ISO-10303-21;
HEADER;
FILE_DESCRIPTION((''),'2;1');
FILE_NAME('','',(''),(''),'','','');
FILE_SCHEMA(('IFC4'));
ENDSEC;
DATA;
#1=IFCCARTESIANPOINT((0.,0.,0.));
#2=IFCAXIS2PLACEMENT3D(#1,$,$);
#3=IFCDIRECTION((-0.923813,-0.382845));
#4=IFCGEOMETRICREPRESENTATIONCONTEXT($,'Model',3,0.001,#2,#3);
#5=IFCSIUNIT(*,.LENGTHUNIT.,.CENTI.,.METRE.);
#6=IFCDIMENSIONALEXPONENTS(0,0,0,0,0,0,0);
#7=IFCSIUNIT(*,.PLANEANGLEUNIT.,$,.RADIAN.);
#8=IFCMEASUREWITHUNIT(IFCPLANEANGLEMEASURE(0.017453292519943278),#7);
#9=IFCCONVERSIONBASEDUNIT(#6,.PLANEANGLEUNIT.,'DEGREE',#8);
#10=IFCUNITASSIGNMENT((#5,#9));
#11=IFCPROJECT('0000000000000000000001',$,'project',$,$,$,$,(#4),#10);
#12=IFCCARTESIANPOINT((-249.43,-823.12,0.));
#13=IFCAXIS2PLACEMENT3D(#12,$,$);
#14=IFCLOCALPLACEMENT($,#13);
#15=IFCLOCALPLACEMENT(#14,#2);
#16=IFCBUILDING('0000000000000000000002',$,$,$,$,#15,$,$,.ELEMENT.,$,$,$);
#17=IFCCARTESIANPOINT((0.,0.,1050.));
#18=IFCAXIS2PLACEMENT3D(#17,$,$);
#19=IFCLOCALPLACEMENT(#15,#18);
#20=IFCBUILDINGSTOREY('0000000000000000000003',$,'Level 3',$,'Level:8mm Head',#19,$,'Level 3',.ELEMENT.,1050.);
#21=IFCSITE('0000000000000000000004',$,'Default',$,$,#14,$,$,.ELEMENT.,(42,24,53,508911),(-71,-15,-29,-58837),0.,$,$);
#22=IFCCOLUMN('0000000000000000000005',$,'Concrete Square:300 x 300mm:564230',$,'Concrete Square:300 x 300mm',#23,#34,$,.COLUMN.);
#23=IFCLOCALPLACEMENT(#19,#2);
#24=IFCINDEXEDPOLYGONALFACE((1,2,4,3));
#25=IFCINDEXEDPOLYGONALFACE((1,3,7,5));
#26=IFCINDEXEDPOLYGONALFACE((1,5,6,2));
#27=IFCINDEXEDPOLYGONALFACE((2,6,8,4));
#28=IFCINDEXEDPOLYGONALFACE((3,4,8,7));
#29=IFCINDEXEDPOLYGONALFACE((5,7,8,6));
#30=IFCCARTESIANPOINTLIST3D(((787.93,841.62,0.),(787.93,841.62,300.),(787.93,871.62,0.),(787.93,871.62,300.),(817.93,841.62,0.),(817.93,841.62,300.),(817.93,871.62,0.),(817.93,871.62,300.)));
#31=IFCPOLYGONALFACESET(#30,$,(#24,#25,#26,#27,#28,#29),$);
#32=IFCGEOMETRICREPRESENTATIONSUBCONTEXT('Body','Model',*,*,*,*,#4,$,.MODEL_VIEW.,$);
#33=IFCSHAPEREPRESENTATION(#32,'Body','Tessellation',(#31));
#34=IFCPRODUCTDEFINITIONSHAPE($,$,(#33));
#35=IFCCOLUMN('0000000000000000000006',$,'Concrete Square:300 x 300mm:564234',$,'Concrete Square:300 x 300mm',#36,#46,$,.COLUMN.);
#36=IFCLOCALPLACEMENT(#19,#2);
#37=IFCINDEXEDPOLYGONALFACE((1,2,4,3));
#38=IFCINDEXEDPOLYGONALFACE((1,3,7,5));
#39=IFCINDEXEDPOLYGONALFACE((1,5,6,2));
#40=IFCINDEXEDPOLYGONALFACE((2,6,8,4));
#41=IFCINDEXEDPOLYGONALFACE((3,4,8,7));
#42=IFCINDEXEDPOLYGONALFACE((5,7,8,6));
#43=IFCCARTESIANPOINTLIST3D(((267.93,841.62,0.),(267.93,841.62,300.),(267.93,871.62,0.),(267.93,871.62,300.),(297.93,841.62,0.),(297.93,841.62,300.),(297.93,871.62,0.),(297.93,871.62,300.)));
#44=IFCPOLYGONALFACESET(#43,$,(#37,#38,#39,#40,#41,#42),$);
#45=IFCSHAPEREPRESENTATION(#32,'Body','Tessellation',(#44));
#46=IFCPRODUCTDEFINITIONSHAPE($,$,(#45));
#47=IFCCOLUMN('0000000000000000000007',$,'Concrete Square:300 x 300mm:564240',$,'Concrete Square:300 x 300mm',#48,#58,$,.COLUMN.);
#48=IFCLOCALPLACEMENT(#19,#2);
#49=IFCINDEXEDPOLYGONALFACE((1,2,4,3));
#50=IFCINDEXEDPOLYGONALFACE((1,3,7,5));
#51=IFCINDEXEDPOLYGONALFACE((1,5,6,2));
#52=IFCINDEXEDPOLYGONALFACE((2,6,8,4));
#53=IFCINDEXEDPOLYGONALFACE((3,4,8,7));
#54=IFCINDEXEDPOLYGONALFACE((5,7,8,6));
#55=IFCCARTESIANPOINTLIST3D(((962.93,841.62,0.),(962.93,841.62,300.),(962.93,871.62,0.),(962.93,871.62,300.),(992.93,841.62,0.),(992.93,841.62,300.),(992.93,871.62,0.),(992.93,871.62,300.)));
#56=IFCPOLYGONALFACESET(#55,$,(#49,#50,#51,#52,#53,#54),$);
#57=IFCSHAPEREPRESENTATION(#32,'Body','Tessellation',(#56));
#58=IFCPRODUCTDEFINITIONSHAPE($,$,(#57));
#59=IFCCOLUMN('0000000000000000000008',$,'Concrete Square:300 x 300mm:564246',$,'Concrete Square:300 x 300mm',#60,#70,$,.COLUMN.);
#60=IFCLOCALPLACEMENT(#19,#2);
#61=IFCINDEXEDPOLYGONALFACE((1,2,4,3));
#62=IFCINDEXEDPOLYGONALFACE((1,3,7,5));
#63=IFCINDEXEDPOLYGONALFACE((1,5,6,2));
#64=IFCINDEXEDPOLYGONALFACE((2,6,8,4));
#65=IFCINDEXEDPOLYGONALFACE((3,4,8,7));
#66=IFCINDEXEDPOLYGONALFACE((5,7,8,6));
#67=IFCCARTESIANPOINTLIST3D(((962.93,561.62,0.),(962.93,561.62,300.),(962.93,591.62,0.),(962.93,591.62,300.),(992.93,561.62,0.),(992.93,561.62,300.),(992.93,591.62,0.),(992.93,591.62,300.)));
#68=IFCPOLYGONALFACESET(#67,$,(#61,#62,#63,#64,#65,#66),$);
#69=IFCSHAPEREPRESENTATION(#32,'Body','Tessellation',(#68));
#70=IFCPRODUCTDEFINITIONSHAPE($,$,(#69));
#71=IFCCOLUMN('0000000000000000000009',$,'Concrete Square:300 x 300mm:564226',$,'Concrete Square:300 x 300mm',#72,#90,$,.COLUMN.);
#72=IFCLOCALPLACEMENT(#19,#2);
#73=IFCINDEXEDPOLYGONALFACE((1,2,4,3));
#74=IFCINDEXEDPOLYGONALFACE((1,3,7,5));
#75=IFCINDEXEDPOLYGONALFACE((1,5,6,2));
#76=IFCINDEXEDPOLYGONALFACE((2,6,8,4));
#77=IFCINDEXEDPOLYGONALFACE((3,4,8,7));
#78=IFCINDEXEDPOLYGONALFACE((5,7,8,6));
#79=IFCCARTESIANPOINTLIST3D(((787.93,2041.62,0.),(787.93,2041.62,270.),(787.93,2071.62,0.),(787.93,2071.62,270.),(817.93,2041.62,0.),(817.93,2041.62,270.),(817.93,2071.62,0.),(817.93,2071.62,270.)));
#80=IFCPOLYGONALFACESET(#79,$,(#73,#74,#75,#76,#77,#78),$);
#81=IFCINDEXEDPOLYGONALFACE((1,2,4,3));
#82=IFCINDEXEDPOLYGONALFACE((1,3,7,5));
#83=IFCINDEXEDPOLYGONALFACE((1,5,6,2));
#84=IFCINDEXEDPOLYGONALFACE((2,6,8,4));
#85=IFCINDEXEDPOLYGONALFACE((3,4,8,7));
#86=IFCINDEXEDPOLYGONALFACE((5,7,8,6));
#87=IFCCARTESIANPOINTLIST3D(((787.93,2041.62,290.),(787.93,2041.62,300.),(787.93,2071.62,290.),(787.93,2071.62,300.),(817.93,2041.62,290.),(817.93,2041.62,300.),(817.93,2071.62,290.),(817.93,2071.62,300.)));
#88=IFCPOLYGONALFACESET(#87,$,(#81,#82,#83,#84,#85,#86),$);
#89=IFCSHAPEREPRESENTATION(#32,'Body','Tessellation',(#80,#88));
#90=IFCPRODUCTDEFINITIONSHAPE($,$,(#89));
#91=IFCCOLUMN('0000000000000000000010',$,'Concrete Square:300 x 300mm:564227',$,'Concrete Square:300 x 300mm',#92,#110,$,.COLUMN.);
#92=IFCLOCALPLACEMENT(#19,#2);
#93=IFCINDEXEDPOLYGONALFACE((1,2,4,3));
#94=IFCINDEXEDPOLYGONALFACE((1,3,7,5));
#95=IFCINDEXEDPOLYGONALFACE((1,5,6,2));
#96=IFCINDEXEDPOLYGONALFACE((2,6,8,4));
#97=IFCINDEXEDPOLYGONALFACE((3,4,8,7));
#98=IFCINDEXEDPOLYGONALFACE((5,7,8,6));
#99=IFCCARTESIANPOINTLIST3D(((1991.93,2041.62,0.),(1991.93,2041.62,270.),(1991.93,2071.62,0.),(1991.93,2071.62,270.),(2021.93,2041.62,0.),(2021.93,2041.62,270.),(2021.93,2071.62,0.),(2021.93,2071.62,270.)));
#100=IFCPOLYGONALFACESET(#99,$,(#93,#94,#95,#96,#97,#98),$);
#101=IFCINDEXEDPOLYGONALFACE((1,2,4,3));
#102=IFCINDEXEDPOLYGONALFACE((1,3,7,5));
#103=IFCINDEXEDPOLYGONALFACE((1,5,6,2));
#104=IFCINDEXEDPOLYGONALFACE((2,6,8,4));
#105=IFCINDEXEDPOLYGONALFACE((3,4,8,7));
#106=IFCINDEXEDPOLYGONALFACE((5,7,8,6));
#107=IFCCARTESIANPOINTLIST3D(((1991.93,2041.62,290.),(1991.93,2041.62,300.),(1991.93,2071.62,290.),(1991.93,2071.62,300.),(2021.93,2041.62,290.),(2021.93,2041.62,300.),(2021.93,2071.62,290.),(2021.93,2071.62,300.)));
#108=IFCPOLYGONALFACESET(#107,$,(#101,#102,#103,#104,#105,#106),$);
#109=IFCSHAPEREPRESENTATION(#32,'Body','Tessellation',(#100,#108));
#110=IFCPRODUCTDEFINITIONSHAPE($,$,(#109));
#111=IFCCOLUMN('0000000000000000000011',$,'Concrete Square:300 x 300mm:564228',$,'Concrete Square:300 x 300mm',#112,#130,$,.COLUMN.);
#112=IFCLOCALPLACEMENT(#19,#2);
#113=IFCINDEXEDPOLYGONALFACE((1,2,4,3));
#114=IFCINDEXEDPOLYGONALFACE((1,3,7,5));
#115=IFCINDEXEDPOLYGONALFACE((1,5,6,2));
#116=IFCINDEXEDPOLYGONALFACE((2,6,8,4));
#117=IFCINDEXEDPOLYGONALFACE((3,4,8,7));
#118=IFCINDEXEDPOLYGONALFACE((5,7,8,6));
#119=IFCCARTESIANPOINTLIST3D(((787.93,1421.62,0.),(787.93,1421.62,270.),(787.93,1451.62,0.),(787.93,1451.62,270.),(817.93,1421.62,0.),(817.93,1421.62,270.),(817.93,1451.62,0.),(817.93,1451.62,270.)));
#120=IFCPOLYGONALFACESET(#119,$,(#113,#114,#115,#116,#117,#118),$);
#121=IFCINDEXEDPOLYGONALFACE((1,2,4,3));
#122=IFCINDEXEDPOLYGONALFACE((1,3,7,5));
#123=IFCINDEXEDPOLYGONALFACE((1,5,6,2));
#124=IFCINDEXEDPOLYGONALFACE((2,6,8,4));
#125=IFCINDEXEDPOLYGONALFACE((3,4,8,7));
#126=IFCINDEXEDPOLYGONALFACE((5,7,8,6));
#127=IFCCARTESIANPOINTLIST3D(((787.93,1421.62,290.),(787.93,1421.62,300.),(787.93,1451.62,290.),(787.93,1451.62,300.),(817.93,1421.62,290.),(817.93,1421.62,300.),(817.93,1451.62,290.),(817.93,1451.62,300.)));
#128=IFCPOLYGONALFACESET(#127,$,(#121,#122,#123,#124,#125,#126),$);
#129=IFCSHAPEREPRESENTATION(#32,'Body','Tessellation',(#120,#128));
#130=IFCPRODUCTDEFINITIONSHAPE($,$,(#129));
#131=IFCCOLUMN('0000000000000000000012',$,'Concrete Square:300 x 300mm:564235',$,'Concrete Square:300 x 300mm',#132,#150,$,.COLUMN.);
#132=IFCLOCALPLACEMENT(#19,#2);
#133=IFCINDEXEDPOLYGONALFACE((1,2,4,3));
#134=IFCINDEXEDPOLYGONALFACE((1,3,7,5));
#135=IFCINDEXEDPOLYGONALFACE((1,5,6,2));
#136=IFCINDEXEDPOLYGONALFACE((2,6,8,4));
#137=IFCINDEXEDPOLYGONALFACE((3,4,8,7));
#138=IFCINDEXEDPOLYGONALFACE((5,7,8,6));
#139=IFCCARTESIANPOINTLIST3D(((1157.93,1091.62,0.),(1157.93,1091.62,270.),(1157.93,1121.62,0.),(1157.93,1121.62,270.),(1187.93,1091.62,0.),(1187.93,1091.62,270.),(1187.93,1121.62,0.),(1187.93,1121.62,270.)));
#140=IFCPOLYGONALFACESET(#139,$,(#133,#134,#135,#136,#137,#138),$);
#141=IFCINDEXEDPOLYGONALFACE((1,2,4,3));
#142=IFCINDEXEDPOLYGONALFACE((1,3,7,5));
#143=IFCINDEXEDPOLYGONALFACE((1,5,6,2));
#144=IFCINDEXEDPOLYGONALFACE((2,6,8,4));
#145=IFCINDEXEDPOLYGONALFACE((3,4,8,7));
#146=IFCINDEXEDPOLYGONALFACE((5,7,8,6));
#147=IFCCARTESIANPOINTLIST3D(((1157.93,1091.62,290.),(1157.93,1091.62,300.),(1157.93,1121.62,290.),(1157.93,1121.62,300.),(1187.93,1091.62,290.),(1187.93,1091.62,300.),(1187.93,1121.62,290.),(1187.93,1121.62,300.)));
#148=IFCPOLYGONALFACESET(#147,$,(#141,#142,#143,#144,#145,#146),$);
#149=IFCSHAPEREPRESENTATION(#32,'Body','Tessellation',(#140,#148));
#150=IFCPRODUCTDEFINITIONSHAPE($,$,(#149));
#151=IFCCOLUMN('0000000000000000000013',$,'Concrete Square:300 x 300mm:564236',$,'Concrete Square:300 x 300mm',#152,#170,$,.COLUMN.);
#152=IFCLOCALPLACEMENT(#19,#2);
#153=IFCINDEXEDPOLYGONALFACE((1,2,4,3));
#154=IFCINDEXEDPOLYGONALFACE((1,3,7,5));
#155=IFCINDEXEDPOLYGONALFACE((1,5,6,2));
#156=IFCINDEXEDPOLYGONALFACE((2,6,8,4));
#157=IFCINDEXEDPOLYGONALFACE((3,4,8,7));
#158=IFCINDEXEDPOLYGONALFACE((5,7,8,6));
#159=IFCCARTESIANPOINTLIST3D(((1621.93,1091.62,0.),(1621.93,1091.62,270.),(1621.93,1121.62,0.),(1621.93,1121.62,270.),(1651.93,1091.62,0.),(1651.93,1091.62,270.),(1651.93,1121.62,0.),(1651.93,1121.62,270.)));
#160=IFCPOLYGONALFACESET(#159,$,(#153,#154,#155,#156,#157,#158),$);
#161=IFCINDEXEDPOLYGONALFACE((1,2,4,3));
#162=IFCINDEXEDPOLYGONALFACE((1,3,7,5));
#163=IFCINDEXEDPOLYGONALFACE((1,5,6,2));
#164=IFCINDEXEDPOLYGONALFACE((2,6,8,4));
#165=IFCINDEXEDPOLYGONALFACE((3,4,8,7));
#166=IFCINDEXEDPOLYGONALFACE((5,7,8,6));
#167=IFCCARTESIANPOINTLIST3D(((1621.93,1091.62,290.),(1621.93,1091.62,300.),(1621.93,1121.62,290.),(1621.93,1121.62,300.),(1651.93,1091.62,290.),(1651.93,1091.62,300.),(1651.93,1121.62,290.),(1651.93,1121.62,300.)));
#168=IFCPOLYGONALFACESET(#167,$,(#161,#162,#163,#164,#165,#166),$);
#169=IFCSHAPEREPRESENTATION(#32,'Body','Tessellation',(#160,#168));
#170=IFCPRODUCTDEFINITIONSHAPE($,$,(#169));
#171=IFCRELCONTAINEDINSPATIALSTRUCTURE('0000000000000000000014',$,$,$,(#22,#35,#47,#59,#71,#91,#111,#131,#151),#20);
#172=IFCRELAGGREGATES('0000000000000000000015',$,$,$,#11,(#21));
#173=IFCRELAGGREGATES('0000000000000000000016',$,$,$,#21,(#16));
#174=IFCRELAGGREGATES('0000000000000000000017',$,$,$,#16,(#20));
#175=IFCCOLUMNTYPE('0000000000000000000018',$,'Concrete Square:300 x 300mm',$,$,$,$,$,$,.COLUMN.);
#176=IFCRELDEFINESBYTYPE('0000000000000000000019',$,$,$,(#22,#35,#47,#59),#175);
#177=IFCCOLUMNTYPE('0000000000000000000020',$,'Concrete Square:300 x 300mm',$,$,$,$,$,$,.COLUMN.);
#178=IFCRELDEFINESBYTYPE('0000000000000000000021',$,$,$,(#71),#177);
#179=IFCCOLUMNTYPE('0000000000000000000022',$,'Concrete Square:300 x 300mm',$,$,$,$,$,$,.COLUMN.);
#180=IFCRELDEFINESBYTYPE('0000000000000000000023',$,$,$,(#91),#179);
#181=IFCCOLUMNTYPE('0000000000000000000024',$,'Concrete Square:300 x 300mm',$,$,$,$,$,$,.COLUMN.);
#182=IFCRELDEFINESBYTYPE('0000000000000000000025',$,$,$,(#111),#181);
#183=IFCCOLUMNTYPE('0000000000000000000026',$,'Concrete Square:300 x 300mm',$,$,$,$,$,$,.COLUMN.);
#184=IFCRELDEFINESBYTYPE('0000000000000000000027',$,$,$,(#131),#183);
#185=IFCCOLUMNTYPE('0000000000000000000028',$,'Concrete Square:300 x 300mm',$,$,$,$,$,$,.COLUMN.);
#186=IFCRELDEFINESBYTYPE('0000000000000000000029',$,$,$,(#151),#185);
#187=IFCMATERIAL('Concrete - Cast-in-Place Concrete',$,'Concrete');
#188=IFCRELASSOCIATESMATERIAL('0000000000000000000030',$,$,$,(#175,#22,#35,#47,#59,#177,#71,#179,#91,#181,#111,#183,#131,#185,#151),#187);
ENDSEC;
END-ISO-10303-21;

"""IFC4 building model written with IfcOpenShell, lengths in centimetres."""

from ifc_helpers import new_model, entity, si_unit, converted_unit, direction, frame, origin, place, context, subcontext, project, spatial, indexed_curve, outline, extrude, source, transform, mapped, material, type_object, type_shapes, element, save


model = new_model("IFC4")

# Units and contexts
model_context = context("Model", 3, precision=0.001, world=origin(), true_north=direction((-0.923813, -0.382845)))
body_context = subcontext(model_context, "Body", "Model", "MODEL_VIEW")
ifc_project = project(units=[si_unit("LENGTHUNIT", "METRE", prefix="CENTI"), converted_unit("PLANEANGLEUNIT", "DEGREE", entity("IfcPlaneAngleMeasure", 0.017453292519943278), si_unit("PLANEANGLEUNIT", "RADIAN"), dimensions=[0, 0, 0, 0, 0, 0, 0])], contexts=[model_context])

# Site, building, storey
site_placement = place(None, frame((-249.43, -823.12, 0.0)))
site = spatial("IfcSite", under=ifc_project, at=site_placement, Name="Default", CompositionType="ELEMENT", RefLatitude=(42, 24, 53, 508911), RefLongitude=(-71, -15, -29, -58837), RefElevation=0.0)
building_placement = place(site_placement, origin())
building = spatial("IfcBuilding", under=site, at=building_placement, CompositionType="ELEMENT")
storey_placement = place(building_placement, frame((0.0, 0.0, 1050.0)))
storey = spatial("IfcBuildingStorey", under=building, at=storey_placement, Name="Level 3", ObjectType="Level:8mm Head", LongName="Level 3", CompositionType="ELEMENT", Elevation=1050.0)

# Columns
ifc_material_1 = material(Name="Concrete - Cast-in-Place Concrete", Category="Concrete")
column_type_1 = type_object("IfcColumnType", Name="Concrete Square:300 x 300mm", PredefinedType="COLUMN", material=ifc_material_1)
shared_shape_1 = source(origin(), body_context, "Body", "SweptSolid", [
    extrude(outline(indexed_curve([(-15.0, -15.0), (15.0, -15.0), (15.0, 15.0), (-15.0, 15.0), (-15.0, -15.0)], self_intersect=False)), frame((0.0, 0.0, 1050.0), z_axis=(0.0, 0.0, 1.0), x_axis=(-1.0, 0.0, 0.0)), (0.0, 0.0, 1.0), 300.0),
])
type_shapes(column_type_1, [shared_shape_1])
for number, where, name in (
    (1, (802.93, 856.62, -1050.0), "Concrete Square:300 x 300mm:564230"),
    (2, (282.93, 856.62, -1050.0), "Concrete Square:300 x 300mm:564234"),
    (3, (977.93, 856.62, -1050.0), "Concrete Square:300 x 300mm:564240"),
    (4, (977.93, 576.62, -1050.0), "Concrete Square:300 x 300mm:564246"),
):
    element("IfcColumn", number, at=place(storey_placement, frame(where)), inside=storey, type_object=column_type_1, material=ifc_material_1, Name=name, ObjectType="Concrete Square:300 x 300mm", PredefinedType="COLUMN", context=body_context, shape_type="MappedRepresentation", body=[
        mapped(shared_shape_1, transform((0.0, 0.0, 0.0), scale=1.0)),
    ])
column_type_2 = type_object("IfcColumnType", Name="Concrete Square:300 x 300mm", PredefinedType="COLUMN", material=ifc_material_1)
shared_shape_2 = source(origin(), body_context, "Body", "SweptSolid", [
    extrude(outline(indexed_curve([(-15.0, -15.0), (15.0, -15.0), (15.0, 15.0), (-15.0, 15.0), (-15.0, -15.0)], self_intersect=False)), frame((802.93, 2056.62, 1050.0), z_axis=(0.0, 0.0, 1.0), x_axis=(-1.0, 0.0, 0.0)), (0.0, 0.0, 1.0), 270.0),
    extrude(outline(indexed_curve([(-15.0, -15.0), (15.0, -15.0), (15.0, 15.0), (-15.0, 15.0), (-15.0, -15.0)], self_intersect=False)), frame((802.93, 2056.62, 1340.0), z_axis=(0.0, 0.0, 1.0), x_axis=(-1.0, 0.0, 0.0)), (0.0, 0.0, 1.0), 10.0),
])
type_shapes(column_type_2, [shared_shape_2])
column_1_placement = place(storey_placement, frame((0.0, 0.0, -1050.0)))
element("IfcColumn", 5, at=column_1_placement, inside=storey, type_object=column_type_2, material=ifc_material_1, Name="Concrete Square:300 x 300mm:564226", ObjectType="Concrete Square:300 x 300mm", PredefinedType="COLUMN", context=body_context, shape_type="MappedRepresentation", body=[
    mapped(shared_shape_2, transform((0.0, 0.0, 0.0), scale=1.0)),
])
column_type_3 = type_object("IfcColumnType", Name="Concrete Square:300 x 300mm", PredefinedType="COLUMN", material=ifc_material_1)
shared_shape_3 = source(origin(), body_context, "Body", "SweptSolid", [
    extrude(outline(indexed_curve([(-15.0, -15.0), (15.0, -15.0), (15.0, 15.0), (-15.0, 15.0), (-15.0, -15.0)], self_intersect=False)), frame((2006.93, 2056.62, 1050.0), z_axis=(0.0, 0.0, 1.0), x_axis=(-1.0, 0.0, 0.0)), (0.0, 0.0, 1.0), 270.0),
    extrude(outline(indexed_curve([(-15.0, -15.0), (15.0, -15.0), (15.0, 15.0), (-15.0, 15.0), (-15.0, -15.0)], self_intersect=False)), frame((2006.93, 2056.62, 1340.0), z_axis=(0.0, 0.0, 1.0), x_axis=(-1.0, 0.0, 0.0)), (0.0, 0.0, 1.0), 10.0),
])
type_shapes(column_type_3, [shared_shape_3])
column_2_placement = place(storey_placement, frame((0.0, 0.0, -1050.0)))
element("IfcColumn", 6, at=column_2_placement, inside=storey, type_object=column_type_3, material=ifc_material_1, Name="Concrete Square:300 x 300mm:564227", ObjectType="Concrete Square:300 x 300mm", PredefinedType="COLUMN", context=body_context, shape_type="MappedRepresentation", body=[
    mapped(shared_shape_3, transform((0.0, 0.0, 0.0), scale=1.0)),
])
column_type_4 = type_object("IfcColumnType", Name="Concrete Square:300 x 300mm", PredefinedType="COLUMN", material=ifc_material_1)
shared_shape_4 = source(origin(), body_context, "Body", "SweptSolid", [
    extrude(outline(indexed_curve([(-15.0, -15.0), (15.0, -15.0), (15.0, 15.0), (-15.0, 15.0), (-15.0, -15.0)], self_intersect=False)), frame((802.93, 1436.62, 1050.0), z_axis=(0.0, 0.0, 1.0), x_axis=(-1.0, 0.0, 0.0)), (0.0, 0.0, 1.0), 270.0),
    extrude(outline(indexed_curve([(-15.0, -15.0), (15.0, -15.0), (15.0, 15.0), (-15.0, 15.0), (-15.0, -15.0)], self_intersect=False)), frame((802.93, 1436.62, 1340.0), z_axis=(0.0, 0.0, 1.0), x_axis=(-1.0, 0.0, 0.0)), (0.0, 0.0, 1.0), 10.0),
])
type_shapes(column_type_4, [shared_shape_4])
column_3_placement = place(storey_placement, frame((0.0, 0.0, -1050.0)))
element("IfcColumn", 7, at=column_3_placement, inside=storey, type_object=column_type_4, material=ifc_material_1, Name="Concrete Square:300 x 300mm:564228", ObjectType="Concrete Square:300 x 300mm", PredefinedType="COLUMN", context=body_context, shape_type="MappedRepresentation", body=[
    mapped(shared_shape_4, transform((0.0, 0.0, 0.0), scale=1.0)),
])
column_type_5 = type_object("IfcColumnType", Name="Concrete Square:300 x 300mm", PredefinedType="COLUMN", material=ifc_material_1)
shared_shape_5 = source(origin(), body_context, "Body", "SweptSolid", [
    extrude(outline(indexed_curve([(-15.0, -15.0), (15.0, -15.0), (15.0, 15.0), (-15.0, 15.0), (-15.0, -15.0)], self_intersect=False)), frame((1172.93, 1106.62, 1050.0), z_axis=(0.0, 0.0, 1.0), x_axis=(-1.0, 0.0, 0.0)), (0.0, 0.0, 1.0), 270.0),
    extrude(outline(indexed_curve([(-15.0, -15.0), (15.0, -15.0), (15.0, 15.0), (-15.0, 15.0), (-15.0, -15.0)], self_intersect=False)), frame((1172.93, 1106.62, 1340.0), z_axis=(0.0, 0.0, 1.0), x_axis=(-1.0, 0.0, 0.0)), (0.0, 0.0, 1.0), 10.0),
])
type_shapes(column_type_5, [shared_shape_5])
column_4_placement = place(storey_placement, frame((0.0, 0.0, -1050.0)))
element("IfcColumn", 8, at=column_4_placement, inside=storey, type_object=column_type_5, material=ifc_material_1, Name="Concrete Square:300 x 300mm:564235", ObjectType="Concrete Square:300 x 300mm", PredefinedType="COLUMN", context=body_context, shape_type="MappedRepresentation", body=[
    mapped(shared_shape_5, transform((0.0, 0.0, 0.0), scale=1.0)),
])
column_type_6 = type_object("IfcColumnType", Name="Concrete Square:300 x 300mm", PredefinedType="COLUMN", material=ifc_material_1)
shared_shape_6 = source(origin(), body_context, "Body", "SweptSolid", [
    extrude(outline(indexed_curve([(-15.0, -15.0), (15.0, -15.0), (15.0, 15.0), (-15.0, 15.0), (-15.0, -15.0)], self_intersect=False)), frame((1636.93, 1106.62, 1050.0), z_axis=(0.0, 0.0, 1.0), x_axis=(-1.0, 0.0, 0.0)), (0.0, 0.0, 1.0), 270.0),
    extrude(outline(indexed_curve([(-15.0, -15.0), (15.0, -15.0), (15.0, 15.0), (-15.0, 15.0), (-15.0, -15.0)], self_intersect=False)), frame((1636.93, 1106.62, 1340.0), z_axis=(0.0, 0.0, 1.0), x_axis=(-1.0, 0.0, 0.0)), (0.0, 0.0, 1.0), 10.0),
])
type_shapes(column_type_6, [shared_shape_6])
column_5_placement = place(storey_placement, frame((0.0, 0.0, -1050.0)))
element("IfcColumn", 9, at=column_5_placement, inside=storey, type_object=column_type_6, material=ifc_material_1, Name="Concrete Square:300 x 300mm:564236", ObjectType="Concrete Square:300 x 300mm", PredefinedType="COLUMN", context=body_context, shape_type="MappedRepresentation", body=[
    mapped(shared_shape_6, transform((0.0, 0.0, 0.0), scale=1.0)),
])

save(model, "model.ifc")
